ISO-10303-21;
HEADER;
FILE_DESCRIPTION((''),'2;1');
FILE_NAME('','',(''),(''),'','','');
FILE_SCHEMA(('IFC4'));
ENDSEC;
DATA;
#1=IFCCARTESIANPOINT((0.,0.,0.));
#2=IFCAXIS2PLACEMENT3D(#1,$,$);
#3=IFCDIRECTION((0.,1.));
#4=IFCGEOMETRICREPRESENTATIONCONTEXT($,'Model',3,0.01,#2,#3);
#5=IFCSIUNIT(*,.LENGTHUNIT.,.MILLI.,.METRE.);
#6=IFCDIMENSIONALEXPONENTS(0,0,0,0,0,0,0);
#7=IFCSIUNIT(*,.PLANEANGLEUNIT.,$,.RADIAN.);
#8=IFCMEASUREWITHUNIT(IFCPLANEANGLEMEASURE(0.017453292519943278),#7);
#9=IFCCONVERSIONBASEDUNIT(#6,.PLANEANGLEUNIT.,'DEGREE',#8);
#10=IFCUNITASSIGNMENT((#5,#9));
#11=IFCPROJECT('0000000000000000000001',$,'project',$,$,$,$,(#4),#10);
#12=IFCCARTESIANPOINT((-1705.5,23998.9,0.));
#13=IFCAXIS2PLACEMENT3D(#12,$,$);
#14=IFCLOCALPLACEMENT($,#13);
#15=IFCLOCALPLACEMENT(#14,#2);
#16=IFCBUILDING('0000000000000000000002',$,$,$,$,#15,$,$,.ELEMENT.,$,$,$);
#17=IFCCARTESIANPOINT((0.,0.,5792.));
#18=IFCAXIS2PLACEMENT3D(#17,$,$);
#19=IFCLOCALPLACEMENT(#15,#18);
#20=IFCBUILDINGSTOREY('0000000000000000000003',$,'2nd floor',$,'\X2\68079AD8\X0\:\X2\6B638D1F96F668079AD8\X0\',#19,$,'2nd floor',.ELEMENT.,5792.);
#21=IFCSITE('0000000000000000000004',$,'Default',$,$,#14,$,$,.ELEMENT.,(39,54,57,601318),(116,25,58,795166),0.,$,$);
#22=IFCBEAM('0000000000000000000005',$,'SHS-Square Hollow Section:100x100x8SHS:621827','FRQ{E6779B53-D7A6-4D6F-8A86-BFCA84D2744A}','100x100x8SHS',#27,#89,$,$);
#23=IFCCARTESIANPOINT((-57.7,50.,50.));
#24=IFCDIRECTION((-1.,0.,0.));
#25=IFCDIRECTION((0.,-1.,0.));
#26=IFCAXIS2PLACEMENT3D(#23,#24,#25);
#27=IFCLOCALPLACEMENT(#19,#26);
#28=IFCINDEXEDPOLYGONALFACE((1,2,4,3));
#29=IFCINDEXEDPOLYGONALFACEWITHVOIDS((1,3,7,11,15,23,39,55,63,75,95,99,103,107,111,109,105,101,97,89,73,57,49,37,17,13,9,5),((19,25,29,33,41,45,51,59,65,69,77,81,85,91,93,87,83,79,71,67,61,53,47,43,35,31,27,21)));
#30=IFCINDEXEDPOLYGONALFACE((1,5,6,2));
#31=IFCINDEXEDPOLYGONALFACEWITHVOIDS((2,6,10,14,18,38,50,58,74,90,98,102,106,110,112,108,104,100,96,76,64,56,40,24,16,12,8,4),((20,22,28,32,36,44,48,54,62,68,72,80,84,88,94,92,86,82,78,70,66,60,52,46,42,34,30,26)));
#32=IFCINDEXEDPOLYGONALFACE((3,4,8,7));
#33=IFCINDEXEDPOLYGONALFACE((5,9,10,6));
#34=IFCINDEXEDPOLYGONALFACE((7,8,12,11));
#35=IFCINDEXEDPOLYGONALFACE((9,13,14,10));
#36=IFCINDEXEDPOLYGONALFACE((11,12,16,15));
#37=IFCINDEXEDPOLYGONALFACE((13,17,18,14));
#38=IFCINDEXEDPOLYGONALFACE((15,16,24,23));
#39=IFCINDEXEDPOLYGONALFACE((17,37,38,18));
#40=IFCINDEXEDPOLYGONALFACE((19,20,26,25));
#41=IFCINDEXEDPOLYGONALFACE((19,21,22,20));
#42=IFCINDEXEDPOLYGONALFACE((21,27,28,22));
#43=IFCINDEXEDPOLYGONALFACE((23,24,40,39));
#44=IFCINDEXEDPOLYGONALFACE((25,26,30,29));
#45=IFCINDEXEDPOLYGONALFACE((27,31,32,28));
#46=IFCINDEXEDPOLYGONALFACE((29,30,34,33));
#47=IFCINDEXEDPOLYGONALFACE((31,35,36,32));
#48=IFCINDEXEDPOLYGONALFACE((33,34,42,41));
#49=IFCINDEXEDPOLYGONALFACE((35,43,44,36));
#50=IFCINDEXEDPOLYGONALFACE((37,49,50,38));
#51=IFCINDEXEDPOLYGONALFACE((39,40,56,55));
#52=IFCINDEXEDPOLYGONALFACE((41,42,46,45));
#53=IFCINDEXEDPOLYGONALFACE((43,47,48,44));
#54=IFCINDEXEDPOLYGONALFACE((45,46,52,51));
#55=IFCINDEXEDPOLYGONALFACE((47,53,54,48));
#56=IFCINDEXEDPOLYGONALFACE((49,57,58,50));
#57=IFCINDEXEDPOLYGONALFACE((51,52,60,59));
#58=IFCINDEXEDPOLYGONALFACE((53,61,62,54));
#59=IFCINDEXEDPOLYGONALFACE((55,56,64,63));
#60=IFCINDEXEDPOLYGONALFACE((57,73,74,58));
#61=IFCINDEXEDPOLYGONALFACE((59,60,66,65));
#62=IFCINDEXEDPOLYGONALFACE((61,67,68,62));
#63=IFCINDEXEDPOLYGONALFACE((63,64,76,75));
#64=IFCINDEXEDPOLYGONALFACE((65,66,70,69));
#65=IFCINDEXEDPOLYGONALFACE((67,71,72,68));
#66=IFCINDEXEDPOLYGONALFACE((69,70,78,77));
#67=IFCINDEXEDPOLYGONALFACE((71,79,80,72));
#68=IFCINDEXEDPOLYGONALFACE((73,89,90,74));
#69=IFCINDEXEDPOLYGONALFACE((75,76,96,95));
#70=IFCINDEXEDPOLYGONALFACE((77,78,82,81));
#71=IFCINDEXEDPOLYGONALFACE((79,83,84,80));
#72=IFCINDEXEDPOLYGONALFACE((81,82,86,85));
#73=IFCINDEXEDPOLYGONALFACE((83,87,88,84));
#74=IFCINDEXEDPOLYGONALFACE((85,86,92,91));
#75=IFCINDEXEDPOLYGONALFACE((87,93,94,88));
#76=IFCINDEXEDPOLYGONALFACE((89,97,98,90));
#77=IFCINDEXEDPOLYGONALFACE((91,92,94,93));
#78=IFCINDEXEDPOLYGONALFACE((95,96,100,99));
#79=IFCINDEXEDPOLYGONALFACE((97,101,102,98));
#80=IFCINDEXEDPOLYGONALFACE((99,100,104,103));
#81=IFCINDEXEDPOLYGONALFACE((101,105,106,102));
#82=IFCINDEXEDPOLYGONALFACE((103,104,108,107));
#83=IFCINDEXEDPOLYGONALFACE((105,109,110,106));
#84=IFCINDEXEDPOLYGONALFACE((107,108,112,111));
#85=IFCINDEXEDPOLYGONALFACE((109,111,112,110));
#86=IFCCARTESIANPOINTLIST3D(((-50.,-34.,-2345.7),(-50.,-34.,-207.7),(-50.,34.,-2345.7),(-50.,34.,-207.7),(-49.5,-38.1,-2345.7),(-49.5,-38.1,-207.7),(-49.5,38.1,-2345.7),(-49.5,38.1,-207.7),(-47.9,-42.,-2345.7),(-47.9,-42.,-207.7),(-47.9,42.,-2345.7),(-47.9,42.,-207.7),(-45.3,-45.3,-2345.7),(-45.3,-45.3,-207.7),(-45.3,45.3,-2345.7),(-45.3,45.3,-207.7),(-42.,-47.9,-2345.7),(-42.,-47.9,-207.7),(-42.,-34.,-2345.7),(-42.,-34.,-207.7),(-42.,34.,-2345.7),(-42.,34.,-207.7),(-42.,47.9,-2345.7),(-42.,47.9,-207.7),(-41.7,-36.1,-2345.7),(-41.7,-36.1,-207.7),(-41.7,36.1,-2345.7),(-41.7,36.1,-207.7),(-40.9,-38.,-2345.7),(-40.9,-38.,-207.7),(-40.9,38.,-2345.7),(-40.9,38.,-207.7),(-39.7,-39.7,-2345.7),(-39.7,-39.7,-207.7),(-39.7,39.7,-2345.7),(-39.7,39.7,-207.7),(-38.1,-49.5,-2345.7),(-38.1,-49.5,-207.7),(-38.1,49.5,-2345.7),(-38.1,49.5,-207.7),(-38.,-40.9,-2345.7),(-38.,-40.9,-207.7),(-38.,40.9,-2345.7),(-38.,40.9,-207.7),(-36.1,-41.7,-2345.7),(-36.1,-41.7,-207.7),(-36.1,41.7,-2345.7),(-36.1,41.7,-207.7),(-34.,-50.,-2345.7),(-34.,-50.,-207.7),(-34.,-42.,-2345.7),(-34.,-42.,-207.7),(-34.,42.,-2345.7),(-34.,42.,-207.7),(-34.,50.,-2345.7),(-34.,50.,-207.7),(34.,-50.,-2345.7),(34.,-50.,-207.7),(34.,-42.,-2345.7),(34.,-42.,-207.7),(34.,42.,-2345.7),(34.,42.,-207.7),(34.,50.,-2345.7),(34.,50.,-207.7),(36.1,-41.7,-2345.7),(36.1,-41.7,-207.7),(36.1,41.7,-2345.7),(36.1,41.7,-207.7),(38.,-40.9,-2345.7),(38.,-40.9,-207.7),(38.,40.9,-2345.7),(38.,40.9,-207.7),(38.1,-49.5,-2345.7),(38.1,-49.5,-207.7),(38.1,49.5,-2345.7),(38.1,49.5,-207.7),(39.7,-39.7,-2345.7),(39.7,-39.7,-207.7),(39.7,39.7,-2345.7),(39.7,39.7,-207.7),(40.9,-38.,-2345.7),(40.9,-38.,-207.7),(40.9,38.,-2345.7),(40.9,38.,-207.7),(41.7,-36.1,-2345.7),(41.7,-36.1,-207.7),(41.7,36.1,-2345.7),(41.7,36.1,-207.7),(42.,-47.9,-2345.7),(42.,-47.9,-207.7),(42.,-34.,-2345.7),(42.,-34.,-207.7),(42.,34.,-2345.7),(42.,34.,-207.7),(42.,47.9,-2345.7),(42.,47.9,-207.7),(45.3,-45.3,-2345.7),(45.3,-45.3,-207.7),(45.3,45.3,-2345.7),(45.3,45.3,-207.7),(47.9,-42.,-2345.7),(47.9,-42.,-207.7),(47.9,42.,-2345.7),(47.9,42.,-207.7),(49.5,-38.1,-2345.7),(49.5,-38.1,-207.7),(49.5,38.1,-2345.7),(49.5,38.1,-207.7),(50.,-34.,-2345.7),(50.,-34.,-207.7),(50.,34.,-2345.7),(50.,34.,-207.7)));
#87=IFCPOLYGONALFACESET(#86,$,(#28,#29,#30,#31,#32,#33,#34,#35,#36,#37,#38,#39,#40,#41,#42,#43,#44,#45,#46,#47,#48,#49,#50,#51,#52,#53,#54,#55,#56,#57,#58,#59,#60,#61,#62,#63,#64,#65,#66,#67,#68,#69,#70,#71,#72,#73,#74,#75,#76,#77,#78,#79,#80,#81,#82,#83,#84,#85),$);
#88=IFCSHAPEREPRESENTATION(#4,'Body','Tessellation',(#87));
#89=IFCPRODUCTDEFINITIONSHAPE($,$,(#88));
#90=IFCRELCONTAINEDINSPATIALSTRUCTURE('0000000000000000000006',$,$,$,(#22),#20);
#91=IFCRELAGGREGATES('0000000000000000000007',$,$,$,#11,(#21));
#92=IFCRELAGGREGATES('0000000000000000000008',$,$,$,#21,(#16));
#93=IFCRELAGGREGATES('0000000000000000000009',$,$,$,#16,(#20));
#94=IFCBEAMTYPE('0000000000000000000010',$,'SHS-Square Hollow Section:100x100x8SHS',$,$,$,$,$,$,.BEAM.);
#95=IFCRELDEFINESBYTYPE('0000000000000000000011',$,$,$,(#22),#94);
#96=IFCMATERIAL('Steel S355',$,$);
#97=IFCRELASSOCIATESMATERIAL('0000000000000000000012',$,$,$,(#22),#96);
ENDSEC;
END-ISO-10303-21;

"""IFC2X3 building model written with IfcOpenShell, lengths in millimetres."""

from ifc_helpers import new_model, entity, si_unit, converted_unit, direction, frame, origin, origin_2d, place, context, project, spatial, hollow_rectangle, extrude, clip, halfspace, material, type_object, element, save


model = new_model("IFC2X3")

# Units and contexts
model_context = context("Model", 3, precision=0.01, world=origin(), true_north=direction((0.0, 1.0)))
ifc_project = project(units=[si_unit("LENGTHUNIT", "METRE", prefix="MILLI"), converted_unit("PLANEANGLEUNIT", "DEGREE", entity("IfcPlaneAngleMeasure", 0.017453292519943278), si_unit("PLANEANGLEUNIT", "RADIAN"), dimensions=[0, 0, 0, 0, 0, 0, 0])], contexts=[model_context])

# Site, building, storey
site_placement = place(None, frame((-1705.5, 23998.9, 0.0)))
site = spatial("IfcSite", under=ifc_project, at=site_placement, Name="Default", CompositionType="ELEMENT", RefLatitude=(39, 54, 57, 601318), RefLongitude=(116, 25, 58, 795166), RefElevation=0.0)
building_placement = place(site_placement, origin())
building = spatial("IfcBuilding", under=site, at=building_placement, CompositionType="ELEMENT")
storey_placement = place(building_placement, frame((0.0, 0.0, 5792.0)))
storey = spatial("IfcBuildingStorey", under=building, at=storey_placement, Name="2nd floor", ObjectType="标高:正负零标高", LongName="2nd floor", CompositionType="ELEMENT", Elevation=5792.0)

# Shared definitions
ifc_material_1 = material(Name="Steel S355")

# Beam
beam_type_1 = type_object("IfcBeamType", Name="SHS-Square Hollow Section:100x100x8SHS", PredefinedType="BEAM")
beam_1_placement = place(storey_placement, frame((-57.7, 50.0, 50.0), z_axis=(-1.0, 0.0, 0.0), x_axis=(0.0, -1.0, 0.0)))
element("IfcBeam", 1, at=beam_1_placement, inside=storey, type_object=beam_type_1, material=ifc_material_1, Name="SHS-Square Hollow Section:100x100x8SHS:621827", Description="FRQ{E6779B53-D7A6-4D6F-8A86-BFCA84D2744A}", ObjectType="100x100x8SHS", context=model_context, shape_type="Clipping", body=[
    clip(clip(extrude(hollow_rectangle(XDim=100.0, YDim=100.0, WallThickness=8.0, InnerFilletRadius=8.0, OuterFilletRadius=16.0, at=origin_2d()), origin(), (0.0, 0.0, -1.0), 2551.4), halfspace(frame((50.0, -5842.0, -2345.7), z_axis=(0.0, 0.0, 1.0), x_axis=(1.0, 0.0, 0.0)), True)), halfspace(frame((50.0, -5842.0, -207.7), z_axis=(0.0, 0.0, -1.0), x_axis=(-1.0, 0.0, 0.0)), True)),
])

save(model, "model.ifc")
